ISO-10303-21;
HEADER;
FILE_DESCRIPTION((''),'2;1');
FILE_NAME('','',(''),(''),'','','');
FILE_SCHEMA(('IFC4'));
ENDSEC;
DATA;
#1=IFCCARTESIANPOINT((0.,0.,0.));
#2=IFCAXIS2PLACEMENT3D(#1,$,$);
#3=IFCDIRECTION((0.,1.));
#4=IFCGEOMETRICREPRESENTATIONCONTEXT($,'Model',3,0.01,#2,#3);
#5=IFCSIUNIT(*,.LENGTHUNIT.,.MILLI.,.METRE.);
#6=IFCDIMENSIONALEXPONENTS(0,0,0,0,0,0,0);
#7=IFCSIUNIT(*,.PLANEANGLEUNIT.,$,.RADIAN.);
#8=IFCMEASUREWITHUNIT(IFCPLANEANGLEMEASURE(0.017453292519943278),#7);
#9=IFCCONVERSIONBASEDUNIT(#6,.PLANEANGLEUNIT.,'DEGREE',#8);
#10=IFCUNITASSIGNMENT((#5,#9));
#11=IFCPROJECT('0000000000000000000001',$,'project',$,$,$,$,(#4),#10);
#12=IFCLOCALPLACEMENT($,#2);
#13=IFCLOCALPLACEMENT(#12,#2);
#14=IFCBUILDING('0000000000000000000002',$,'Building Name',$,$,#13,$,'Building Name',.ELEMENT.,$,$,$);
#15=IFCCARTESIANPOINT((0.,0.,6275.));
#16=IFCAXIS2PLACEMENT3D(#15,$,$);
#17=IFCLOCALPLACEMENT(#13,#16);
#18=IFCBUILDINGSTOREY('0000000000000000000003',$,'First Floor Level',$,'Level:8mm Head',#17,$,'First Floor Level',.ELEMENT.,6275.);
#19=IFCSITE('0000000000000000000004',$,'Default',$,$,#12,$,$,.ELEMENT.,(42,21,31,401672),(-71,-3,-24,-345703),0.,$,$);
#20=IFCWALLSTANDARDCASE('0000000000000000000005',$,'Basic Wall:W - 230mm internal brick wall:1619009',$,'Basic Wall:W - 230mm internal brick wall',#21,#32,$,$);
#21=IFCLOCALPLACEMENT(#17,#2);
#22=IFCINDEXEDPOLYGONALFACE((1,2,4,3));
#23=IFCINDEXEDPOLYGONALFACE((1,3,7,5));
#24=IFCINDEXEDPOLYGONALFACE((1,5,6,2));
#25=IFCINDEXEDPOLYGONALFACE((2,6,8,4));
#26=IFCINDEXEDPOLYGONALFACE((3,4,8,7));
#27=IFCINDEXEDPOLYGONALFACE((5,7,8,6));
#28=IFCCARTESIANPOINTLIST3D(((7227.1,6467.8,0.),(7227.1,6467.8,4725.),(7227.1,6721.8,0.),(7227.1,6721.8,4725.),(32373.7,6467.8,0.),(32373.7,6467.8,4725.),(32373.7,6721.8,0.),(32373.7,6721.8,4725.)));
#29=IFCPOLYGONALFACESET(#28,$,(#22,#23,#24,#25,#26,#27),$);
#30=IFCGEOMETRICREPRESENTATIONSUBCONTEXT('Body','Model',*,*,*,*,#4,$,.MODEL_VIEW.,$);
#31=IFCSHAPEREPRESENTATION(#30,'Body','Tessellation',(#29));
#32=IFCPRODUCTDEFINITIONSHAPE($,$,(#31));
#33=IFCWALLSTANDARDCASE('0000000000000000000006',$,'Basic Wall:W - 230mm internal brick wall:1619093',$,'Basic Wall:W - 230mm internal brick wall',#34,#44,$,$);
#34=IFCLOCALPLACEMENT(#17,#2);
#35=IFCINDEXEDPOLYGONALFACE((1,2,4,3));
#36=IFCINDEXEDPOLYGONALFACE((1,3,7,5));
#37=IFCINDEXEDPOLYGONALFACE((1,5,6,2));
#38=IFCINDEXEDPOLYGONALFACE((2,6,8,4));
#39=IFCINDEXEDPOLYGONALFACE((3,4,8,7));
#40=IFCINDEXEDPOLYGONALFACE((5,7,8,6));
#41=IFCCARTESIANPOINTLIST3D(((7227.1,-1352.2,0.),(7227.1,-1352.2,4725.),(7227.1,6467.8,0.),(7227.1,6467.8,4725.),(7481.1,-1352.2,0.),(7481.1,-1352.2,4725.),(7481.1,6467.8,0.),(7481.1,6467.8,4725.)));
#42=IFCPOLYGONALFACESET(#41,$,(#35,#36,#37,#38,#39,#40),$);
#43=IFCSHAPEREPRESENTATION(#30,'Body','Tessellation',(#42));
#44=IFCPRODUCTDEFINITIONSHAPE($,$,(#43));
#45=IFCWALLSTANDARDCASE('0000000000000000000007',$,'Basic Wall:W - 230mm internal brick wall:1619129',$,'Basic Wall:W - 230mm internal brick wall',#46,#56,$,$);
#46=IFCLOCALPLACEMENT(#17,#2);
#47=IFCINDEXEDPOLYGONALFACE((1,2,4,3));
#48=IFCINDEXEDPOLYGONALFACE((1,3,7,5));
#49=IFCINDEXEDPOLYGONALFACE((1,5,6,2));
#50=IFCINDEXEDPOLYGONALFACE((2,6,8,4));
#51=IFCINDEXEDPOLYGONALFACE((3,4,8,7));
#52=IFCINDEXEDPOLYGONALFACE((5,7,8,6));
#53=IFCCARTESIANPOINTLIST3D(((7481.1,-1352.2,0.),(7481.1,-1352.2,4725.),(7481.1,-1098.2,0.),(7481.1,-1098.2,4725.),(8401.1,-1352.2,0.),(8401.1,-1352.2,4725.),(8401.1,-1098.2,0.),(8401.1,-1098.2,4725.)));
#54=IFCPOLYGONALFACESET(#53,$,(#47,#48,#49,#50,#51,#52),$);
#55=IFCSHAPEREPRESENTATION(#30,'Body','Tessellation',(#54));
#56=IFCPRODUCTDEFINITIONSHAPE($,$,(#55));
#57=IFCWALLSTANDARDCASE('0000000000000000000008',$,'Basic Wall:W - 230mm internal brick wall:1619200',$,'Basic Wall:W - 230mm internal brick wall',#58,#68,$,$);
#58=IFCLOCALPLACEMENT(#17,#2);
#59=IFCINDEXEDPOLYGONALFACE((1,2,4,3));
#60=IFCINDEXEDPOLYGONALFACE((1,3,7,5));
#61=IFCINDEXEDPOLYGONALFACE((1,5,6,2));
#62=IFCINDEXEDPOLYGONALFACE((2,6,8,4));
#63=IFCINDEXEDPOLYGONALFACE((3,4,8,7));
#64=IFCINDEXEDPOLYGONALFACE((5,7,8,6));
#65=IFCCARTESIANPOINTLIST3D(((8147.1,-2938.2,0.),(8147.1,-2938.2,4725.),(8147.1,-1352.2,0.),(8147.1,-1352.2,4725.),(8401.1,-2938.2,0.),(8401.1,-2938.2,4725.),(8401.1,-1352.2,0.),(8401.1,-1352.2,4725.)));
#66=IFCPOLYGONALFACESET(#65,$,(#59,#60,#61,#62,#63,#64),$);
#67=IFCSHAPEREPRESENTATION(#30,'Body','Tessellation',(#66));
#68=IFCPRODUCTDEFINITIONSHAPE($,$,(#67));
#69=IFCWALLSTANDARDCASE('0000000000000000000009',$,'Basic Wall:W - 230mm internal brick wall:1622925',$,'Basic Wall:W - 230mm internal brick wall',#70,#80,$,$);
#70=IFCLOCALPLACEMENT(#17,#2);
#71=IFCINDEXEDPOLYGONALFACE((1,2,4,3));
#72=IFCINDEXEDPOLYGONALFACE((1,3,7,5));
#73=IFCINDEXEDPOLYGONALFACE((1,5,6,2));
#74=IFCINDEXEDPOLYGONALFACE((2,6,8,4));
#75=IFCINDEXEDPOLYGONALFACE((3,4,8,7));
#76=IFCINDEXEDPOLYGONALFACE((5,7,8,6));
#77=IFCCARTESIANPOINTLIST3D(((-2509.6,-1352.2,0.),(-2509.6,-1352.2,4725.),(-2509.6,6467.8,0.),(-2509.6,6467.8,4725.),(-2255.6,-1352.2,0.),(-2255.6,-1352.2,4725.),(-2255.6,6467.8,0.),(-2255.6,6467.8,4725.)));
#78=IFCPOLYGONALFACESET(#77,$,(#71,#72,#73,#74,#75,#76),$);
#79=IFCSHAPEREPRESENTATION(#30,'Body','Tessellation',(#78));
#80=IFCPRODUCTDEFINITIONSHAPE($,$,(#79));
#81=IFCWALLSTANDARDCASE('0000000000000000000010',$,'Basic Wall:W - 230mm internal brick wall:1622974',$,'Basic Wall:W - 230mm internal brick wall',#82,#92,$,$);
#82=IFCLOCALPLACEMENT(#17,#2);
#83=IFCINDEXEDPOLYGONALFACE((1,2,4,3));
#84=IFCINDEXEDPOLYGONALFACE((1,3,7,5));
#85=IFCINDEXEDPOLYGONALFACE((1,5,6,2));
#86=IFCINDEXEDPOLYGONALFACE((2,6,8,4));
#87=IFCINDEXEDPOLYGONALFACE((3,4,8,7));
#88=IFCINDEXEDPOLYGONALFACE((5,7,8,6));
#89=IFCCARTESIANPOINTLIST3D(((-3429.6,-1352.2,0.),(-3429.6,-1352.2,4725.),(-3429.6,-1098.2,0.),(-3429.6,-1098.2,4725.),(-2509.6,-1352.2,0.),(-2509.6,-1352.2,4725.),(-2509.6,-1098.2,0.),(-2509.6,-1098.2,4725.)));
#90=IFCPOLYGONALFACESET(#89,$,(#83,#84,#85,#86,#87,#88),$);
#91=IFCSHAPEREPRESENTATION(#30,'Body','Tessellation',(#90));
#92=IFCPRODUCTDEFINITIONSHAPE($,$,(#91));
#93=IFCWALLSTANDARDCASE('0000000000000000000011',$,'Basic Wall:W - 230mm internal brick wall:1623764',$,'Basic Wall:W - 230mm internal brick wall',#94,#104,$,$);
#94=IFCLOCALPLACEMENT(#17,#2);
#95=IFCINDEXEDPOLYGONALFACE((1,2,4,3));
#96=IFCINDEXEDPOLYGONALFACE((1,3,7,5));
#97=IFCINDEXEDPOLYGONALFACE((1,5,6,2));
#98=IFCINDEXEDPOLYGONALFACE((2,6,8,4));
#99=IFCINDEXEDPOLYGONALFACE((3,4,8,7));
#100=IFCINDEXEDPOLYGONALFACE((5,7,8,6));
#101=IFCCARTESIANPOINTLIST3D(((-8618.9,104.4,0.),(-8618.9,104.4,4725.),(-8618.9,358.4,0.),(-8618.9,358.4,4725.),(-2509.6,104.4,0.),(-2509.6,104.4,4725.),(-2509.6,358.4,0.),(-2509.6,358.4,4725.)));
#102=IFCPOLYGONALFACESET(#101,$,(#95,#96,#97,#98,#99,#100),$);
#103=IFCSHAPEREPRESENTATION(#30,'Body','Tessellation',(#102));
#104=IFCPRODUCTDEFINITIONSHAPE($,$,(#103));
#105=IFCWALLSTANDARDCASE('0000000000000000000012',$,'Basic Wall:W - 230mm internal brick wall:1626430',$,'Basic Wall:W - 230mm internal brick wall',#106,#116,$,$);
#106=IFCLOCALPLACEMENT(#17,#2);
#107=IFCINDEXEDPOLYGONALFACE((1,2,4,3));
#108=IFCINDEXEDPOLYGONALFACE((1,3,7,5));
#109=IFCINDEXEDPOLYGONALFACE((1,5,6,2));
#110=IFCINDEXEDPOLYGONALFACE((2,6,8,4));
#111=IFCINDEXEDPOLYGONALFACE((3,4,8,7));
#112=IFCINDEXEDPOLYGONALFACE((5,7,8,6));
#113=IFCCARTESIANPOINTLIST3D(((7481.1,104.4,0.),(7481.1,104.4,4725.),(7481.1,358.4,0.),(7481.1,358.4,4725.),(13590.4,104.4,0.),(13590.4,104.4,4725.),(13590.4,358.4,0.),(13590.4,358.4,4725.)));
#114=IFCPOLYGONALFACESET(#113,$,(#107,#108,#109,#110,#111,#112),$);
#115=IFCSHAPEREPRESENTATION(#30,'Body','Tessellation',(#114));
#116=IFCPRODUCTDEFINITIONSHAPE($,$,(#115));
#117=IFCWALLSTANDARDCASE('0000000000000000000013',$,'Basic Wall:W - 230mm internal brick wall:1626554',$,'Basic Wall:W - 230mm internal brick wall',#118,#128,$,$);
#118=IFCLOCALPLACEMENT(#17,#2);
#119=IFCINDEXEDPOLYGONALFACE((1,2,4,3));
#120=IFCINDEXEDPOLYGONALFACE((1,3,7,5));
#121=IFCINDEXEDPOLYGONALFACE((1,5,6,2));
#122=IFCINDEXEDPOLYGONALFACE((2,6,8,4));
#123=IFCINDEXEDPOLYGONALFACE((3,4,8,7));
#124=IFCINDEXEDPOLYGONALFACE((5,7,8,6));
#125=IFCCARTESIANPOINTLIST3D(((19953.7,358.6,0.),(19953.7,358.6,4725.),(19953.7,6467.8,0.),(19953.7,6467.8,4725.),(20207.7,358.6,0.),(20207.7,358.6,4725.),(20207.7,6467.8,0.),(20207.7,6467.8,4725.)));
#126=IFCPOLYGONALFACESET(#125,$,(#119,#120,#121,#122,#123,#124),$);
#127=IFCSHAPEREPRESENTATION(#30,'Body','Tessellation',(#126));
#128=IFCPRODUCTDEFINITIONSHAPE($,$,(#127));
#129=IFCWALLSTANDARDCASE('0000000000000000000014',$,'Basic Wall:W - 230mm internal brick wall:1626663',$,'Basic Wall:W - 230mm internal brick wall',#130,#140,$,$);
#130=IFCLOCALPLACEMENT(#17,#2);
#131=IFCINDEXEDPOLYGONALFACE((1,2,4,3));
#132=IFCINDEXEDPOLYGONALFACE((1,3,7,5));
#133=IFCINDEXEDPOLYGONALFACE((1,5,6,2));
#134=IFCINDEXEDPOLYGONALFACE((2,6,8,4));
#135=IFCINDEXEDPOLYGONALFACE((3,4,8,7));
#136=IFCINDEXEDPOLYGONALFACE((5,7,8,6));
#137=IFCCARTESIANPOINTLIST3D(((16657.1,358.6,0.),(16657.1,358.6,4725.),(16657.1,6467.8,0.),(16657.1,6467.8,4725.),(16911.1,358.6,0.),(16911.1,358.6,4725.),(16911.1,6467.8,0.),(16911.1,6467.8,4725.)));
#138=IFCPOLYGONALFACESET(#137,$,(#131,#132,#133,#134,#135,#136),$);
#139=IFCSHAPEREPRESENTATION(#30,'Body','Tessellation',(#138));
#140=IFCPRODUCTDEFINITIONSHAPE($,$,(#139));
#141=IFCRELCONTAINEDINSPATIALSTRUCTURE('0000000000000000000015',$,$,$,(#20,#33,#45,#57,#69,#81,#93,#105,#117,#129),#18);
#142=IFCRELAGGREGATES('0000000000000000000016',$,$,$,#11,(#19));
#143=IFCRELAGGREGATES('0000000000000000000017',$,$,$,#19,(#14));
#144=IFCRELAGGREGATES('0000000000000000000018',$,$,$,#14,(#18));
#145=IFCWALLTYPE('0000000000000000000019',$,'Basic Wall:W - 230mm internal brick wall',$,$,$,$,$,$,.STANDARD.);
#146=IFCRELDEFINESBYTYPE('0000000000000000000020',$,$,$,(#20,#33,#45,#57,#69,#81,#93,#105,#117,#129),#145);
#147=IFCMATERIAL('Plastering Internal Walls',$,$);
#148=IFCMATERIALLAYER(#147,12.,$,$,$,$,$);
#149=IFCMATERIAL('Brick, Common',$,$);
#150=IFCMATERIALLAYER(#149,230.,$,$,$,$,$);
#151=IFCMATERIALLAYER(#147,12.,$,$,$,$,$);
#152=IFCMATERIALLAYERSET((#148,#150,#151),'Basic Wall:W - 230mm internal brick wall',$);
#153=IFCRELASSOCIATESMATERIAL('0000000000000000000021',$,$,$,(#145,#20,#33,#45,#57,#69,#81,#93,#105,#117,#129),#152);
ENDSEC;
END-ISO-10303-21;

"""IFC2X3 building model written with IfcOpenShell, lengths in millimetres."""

from ifc_helpers import new_model, entity, si_unit, converted_unit, direction, frame, frame_2d, origin, place, context, subcontext, project, spatial, rectangle, extrude, material, layer, layer_set, layer_usage, type_object, element, save


model = new_model("IFC2X3")

# Units and contexts
model_context = context("Model", 3, precision=0.01, world=origin(), true_north=direction((0.0, 1.0)))
body_context = subcontext(model_context, "Body", "Model", "MODEL_VIEW")
ifc_project = project(units=[si_unit("LENGTHUNIT", "METRE", prefix="MILLI"), converted_unit("PLANEANGLEUNIT", "DEGREE", entity("IfcPlaneAngleMeasure", 0.017453292519943278), si_unit("PLANEANGLEUNIT", "RADIAN"), dimensions=[0, 0, 0, 0, 0, 0, 0])], contexts=[model_context])

# Site, building, storey
site_placement = place(None, origin())
site = spatial("IfcSite", under=ifc_project, at=site_placement, Name="Default", CompositionType="ELEMENT", RefLatitude=(42, 21, 31, 401672), RefLongitude=(-71, -3, -24, -345703), RefElevation=0.0)
building_placement = place(site_placement, origin())
building = spatial("IfcBuilding", under=site, at=building_placement, Name="Building Name", LongName="Building Name", CompositionType="ELEMENT")
storey_placement = place(building_placement, frame((0.0, 0.0, 6275.0)))
storey = spatial("IfcBuildingStorey", under=building, at=storey_placement, Name="First Floor Level", ObjectType="Level:8mm Head", LongName="First Floor Level", CompositionType="ELEMENT", Elevation=6275.0)

# Walls
ifc_material_1 = material(Name="Brick, Common")
ifc_material_2 = material(Name="Plastering Internal Walls")
ifc_layer_1 = layer(ifc_material_2, 12.0)
ifc_layer_2 = layer(ifc_material_1, 230.0)
ifc_layer_3 = layer(ifc_material_2, 12.0)
ifc_layer_set_1 = layer_set([ifc_layer_1, ifc_layer_2, ifc_layer_3], Name="Basic Wall:W - 230mm internal brick wall")
wall_type_1 = type_object("IfcWallType", Name="Basic Wall:W - 230mm internal brick wall", PredefinedType="STANDARD", material=ifc_layer_set_1)
ifc_layer_usage_1 = layer_usage(ifc_layer_set_1, "AXIS2", "NEGATIVE", 127.0)
wall_1_placement = place(storey_placement, frame((32373.7, 6594.8, 0.0), z_axis=(0.0, 0.0, 1.0), x_axis=(-1.0, 0.0, 0.0)))
element("IfcWallStandardCase", 1, at=wall_1_placement, inside=storey, type_object=wall_type_1, material=ifc_layer_usage_1, Name="Basic Wall:W - 230mm internal brick wall:1619009", ObjectType="Basic Wall:W - 230mm internal brick wall", context=body_context, shape_type="SweptSolid", body=[
    extrude(rectangle(XDim=25146.7, YDim=254.0, at=frame_2d((12573.3, 0.0), x_axis=(-1.0, 0.0))), origin(), (0.0, 0.0, 1.0), 4725.0),
])
ifc_layer_usage_2 = layer_usage(ifc_layer_set_1, "AXIS2", "NEGATIVE", 127.0)
wall_2_placement = place(storey_placement, frame((7354.1, 6467.8, 0.0), z_axis=(0.0, 0.0, 1.0), x_axis=(0.0, -1.0, 0.0)))
element("IfcWallStandardCase", 2, at=wall_2_placement, inside=storey, type_object=wall_type_1, material=ifc_layer_usage_2, Name="Basic Wall:W - 230mm internal brick wall:1619093", ObjectType="Basic Wall:W - 230mm internal brick wall", context=body_context, shape_type="SweptSolid", body=[
    extrude(rectangle(XDim=7820.0, YDim=254.0, at=frame_2d((3910.0, 0.0), x_axis=(-1.0, 0.0))), origin(), (0.0, 0.0, 1.0), 4725.0),
])
ifc_layer_usage_3 = layer_usage(ifc_layer_set_1, "AXIS2", "NEGATIVE", 127.0)
wall_3_placement = place(storey_placement, frame((7481.1, -1225.2, 0.0)))
element("IfcWallStandardCase", 3, at=wall_3_placement, inside=storey, type_object=wall_type_1, material=ifc_layer_usage_3, Name="Basic Wall:W - 230mm internal brick wall:1619129", ObjectType="Basic Wall:W - 230mm internal brick wall", context=body_context, shape_type="SweptSolid", body=[
    extrude(rectangle(XDim=920.0, YDim=254.0, at=frame_2d((460.0, 0.0), x_axis=(-1.0, 0.0))), origin(), (0.0, 0.0, 1.0), 4725.0),
])
ifc_layer_usage_4 = layer_usage(ifc_layer_set_1, "AXIS2", "NEGATIVE", 127.0)
wall_4_placement = place(storey_placement, frame((8274.1, -1352.2, 0.0), z_axis=(0.0, 0.0, 1.0), x_axis=(0.0, -1.0, 0.0)))
element("IfcWallStandardCase", 4, at=wall_4_placement, inside=storey, type_object=wall_type_1, material=ifc_layer_usage_4, Name="Basic Wall:W - 230mm internal brick wall:1619200", ObjectType="Basic Wall:W - 230mm internal brick wall", context=body_context, shape_type="SweptSolid", body=[
    extrude(rectangle(XDim=1586.0, YDim=254.0, at=frame_2d((793.0, 0.0), x_axis=(-1.0, 0.0))), origin(), (0.0, 0.0, 1.0), 4725.0),
])
ifc_layer_usage_5 = layer_usage(ifc_layer_set_1, "AXIS2", "NEGATIVE", 127.0)
wall_5_placement = place(storey_placement, frame((-2382.6, 6467.8, 0.0), z_axis=(0.0, 0.0, 1.0), x_axis=(0.0, -1.0, 0.0)))
element("IfcWallStandardCase", 5, at=wall_5_placement, inside=storey, type_object=wall_type_1, material=ifc_layer_usage_5, Name="Basic Wall:W - 230mm internal brick wall:1622925", ObjectType="Basic Wall:W - 230mm internal brick wall", context=body_context, shape_type="SweptSolid", body=[
    extrude(rectangle(XDim=7820.0, YDim=254.0, at=frame_2d((3910.0, 0.0), x_axis=(-1.0, 0.0))), origin(), (0.0, 0.0, 1.0), 4725.0),
])
ifc_layer_usage_6 = layer_usage(ifc_layer_set_1, "AXIS2", "NEGATIVE", 127.0)
wall_6_placement = place(storey_placement, frame((-2509.6, -1225.2, 0.0), z_axis=(0.0, 0.0, 1.0), x_axis=(-1.0, 0.0, 0.0)))
element("IfcWallStandardCase", 6, at=wall_6_placement, inside=storey, type_object=wall_type_1, material=ifc_layer_usage_6, Name="Basic Wall:W - 230mm internal brick wall:1622974", ObjectType="Basic Wall:W - 230mm internal brick wall", context=body_context, shape_type="SweptSolid", body=[
    extrude(rectangle(XDim=920.0, YDim=254.0, at=frame_2d((460.0, 0.0), x_axis=(-1.0, 0.0))), origin(), (0.0, 0.0, 1.0), 4725.0),
])
ifc_layer_usage_7 = layer_usage(ifc_layer_set_1, "AXIS2", "NEGATIVE", 127.0)
wall_7_placement = place(storey_placement, frame((-2509.6, 231.4, 0.0), z_axis=(0.0, 0.0, 1.0), x_axis=(-1.0, 0.0, 0.0)))
element("IfcWallStandardCase", 7, at=wall_7_placement, inside=storey, type_object=wall_type_1, material=ifc_layer_usage_7, Name="Basic Wall:W - 230mm internal brick wall:1623764", ObjectType="Basic Wall:W - 230mm internal brick wall", context=body_context, shape_type="SweptSolid", body=[
    extrude(rectangle(XDim=6109.3, YDim=254.0, at=frame_2d((3054.7, 0.0), x_axis=(-1.0, 0.0))), origin(), (0.0, 0.0, 1.0), 4725.0),
])
ifc_layer_usage_8 = layer_usage(ifc_layer_set_1, "AXIS2", "NEGATIVE", 127.0)
wall_8_placement = place(storey_placement, frame((13590.4, 231.4, 0.0), z_axis=(0.0, 0.0, 1.0), x_axis=(-1.0, 0.0, 0.0)))
element("IfcWallStandardCase", 8, at=wall_8_placement, inside=storey, type_object=wall_type_1, material=ifc_layer_usage_8, Name="Basic Wall:W - 230mm internal brick wall:1626430", ObjectType="Basic Wall:W - 230mm internal brick wall", context=body_context, shape_type="SweptSolid", body=[
    extrude(rectangle(XDim=6109.3, YDim=254.0, at=frame_2d((3054.7, 0.0), x_axis=(-1.0, 0.0))), origin(), (0.0, 0.0, 1.0), 4725.0),
])
ifc_layer_usage_9 = layer_usage(ifc_layer_set_1, "AXIS2", "NEGATIVE", 127.0)
wall_9_placement = place(storey_placement, frame((20080.7, 358.6, 0.0), z_axis=(0.0, 0.0, 1.0), x_axis=(0.0, 1.0, 0.0)))
element("IfcWallStandardCase", 9, at=wall_9_placement, inside=storey, type_object=wall_type_1, material=ifc_layer_usage_9, Name="Basic Wall:W - 230mm internal brick wall:1626554", ObjectType="Basic Wall:W - 230mm internal brick wall", context=body_context, shape_type="SweptSolid", body=[
    extrude(rectangle(XDim=6109.1, YDim=254.0, at=frame_2d((3054.6, 0.0), x_axis=(-1.0, 0.0))), origin(), (0.0, 0.0, 1.0), 4725.0),
])
ifc_layer_usage_10 = layer_usage(ifc_layer_set_1, "AXIS2", "NEGATIVE", 127.0)
wall_10_placement = place(storey_placement, frame((16784.1, 358.6, 0.0), z_axis=(0.0, 0.0, 1.0), x_axis=(0.0, 1.0, 0.0)))
element("IfcWallStandardCase", 10, at=wall_10_placement, inside=storey, type_object=wall_type_1, material=ifc_layer_usage_10, Name="Basic Wall:W - 230mm internal brick wall:1626663", ObjectType="Basic Wall:W - 230mm internal brick wall", context=body_context, shape_type="SweptSolid", body=[
    extrude(rectangle(XDim=6109.1, YDim=254.0, at=frame_2d((3054.6, 0.0), x_axis=(-1.0, 0.0))), origin(), (0.0, 0.0, 1.0), 4725.0),
])

save(model, "model.ifc")
